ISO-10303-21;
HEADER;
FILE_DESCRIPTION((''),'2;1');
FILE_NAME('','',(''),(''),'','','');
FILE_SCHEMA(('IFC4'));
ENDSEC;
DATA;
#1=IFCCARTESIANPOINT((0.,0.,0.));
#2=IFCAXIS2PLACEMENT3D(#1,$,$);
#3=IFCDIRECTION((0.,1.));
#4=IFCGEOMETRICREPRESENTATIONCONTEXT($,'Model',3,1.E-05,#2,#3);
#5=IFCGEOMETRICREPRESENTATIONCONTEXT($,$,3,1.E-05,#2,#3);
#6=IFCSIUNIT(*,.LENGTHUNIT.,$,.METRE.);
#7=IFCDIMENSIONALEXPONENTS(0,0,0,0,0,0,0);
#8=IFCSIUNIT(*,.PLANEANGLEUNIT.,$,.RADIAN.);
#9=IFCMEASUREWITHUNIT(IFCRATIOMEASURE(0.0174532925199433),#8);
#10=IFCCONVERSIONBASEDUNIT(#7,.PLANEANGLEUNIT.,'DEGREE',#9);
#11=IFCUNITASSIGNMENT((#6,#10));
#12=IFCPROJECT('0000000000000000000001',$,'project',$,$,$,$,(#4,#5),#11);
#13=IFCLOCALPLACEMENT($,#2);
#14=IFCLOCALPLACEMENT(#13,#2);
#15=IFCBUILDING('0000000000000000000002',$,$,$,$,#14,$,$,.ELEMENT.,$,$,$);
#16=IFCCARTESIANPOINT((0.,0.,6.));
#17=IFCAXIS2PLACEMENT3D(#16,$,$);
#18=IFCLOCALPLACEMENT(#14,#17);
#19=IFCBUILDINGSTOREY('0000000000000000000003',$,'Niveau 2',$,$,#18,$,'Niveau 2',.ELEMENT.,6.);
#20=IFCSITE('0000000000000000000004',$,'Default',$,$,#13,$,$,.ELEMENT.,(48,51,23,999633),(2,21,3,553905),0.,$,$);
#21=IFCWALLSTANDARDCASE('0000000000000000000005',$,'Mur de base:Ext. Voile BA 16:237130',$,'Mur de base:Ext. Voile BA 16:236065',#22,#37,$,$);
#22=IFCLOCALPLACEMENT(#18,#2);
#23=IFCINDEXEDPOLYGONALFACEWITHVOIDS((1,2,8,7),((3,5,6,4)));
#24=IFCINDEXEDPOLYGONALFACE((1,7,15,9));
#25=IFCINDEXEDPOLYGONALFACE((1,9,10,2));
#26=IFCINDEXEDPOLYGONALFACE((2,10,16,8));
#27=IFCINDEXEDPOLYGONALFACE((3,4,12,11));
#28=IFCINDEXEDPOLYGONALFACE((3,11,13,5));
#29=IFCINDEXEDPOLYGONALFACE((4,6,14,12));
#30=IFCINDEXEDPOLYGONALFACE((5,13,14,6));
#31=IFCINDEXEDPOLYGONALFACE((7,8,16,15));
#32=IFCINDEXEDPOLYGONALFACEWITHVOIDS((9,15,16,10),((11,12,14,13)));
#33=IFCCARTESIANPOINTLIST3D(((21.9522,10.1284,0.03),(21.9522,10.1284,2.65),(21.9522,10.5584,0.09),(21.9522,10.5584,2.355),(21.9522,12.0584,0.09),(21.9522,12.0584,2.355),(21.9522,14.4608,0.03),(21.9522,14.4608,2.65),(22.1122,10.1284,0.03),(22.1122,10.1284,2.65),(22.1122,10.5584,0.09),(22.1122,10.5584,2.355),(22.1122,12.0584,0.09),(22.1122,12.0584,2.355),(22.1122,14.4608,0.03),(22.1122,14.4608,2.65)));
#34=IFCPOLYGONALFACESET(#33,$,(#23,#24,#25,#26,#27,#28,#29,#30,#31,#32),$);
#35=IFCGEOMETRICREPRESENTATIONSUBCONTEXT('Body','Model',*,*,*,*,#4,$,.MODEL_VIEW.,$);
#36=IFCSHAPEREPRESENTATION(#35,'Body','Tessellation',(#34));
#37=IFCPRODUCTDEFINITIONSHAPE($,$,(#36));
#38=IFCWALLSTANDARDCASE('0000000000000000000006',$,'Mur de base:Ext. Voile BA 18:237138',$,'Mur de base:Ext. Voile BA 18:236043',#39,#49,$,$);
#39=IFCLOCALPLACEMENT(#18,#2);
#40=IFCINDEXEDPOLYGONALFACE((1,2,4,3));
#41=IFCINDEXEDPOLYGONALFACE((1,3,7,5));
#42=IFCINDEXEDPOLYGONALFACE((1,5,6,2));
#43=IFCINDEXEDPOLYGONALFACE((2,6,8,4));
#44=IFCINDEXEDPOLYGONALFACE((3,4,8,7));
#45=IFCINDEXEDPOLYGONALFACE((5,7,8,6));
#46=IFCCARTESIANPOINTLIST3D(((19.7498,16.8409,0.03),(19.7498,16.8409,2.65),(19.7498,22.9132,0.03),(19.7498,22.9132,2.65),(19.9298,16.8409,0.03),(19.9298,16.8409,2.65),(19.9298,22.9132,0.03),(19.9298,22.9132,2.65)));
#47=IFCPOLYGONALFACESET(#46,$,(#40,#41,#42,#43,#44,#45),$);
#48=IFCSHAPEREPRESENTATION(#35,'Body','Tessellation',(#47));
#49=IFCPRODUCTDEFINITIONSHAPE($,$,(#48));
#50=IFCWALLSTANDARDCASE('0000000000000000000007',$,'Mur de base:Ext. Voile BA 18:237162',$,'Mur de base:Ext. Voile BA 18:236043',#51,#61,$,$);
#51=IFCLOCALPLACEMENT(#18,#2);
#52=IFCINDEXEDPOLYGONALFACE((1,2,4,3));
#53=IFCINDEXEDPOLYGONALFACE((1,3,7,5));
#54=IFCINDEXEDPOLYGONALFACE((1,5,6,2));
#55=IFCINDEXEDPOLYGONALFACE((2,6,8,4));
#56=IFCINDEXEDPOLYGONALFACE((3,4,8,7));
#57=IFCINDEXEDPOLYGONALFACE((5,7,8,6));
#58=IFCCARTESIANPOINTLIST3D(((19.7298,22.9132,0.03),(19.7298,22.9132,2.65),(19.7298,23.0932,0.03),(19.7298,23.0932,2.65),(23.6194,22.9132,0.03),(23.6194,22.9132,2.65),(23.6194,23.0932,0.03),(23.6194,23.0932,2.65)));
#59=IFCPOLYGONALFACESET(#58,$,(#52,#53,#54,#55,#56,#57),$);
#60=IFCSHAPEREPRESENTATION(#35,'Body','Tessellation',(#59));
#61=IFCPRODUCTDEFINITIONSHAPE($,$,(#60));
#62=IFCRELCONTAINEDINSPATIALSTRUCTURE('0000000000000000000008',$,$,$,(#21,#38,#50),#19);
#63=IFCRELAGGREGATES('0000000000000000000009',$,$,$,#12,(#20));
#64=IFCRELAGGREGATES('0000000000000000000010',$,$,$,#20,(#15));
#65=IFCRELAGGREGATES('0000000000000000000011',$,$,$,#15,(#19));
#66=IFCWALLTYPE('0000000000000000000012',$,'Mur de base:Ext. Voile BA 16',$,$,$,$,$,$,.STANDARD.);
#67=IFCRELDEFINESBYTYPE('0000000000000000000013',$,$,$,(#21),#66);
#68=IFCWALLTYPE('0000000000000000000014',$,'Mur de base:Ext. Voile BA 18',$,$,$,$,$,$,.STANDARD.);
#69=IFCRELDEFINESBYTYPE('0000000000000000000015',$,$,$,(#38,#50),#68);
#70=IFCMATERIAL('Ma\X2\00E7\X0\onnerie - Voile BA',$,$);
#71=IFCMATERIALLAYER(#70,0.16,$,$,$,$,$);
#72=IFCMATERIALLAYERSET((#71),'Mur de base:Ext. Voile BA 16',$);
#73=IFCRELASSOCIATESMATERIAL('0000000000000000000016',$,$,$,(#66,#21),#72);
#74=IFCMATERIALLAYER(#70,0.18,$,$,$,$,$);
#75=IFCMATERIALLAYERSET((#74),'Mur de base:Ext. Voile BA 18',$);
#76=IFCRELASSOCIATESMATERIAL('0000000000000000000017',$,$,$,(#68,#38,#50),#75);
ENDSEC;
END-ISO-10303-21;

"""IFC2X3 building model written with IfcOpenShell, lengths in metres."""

from ifc_helpers import new_model, entity, si_unit, converted_unit, direction, frame, frame_2d, origin, origin_2d_with_axis, place, context, subcontext, project, spatial, rectangle, extrude, material, layer, layer_set, layer_usage, type_object, element, save


model = new_model("IFC2X3")

# Units and contexts
model_context = context("Model", 3, precision=1e-05, world=origin(), true_north=direction((0.0, 1.0)))
context_of_model = context(None, 3, precision=1e-05, world=origin(), true_north=direction((0.0, 1.0)))
body_context = subcontext(model_context, "Body", "Model", "MODEL_VIEW")
ifc_project = project(units=[si_unit("LENGTHUNIT", "METRE"), converted_unit("PLANEANGLEUNIT", "DEGREE", entity("IfcRatioMeasure", 0.0174532925199433), si_unit("PLANEANGLEUNIT", "RADIAN"), dimensions=[0, 0, 0, 0, 0, 0, 0])], contexts=[model_context, context_of_model])

# Site, building, storey
site_placement = place(None, origin())
site = spatial("IfcSite", under=ifc_project, at=site_placement, Name="Default", CompositionType="ELEMENT", RefLatitude=(48, 51, 23, 999633), RefLongitude=(2, 21, 3, 553905), RefElevation=0.0)
building_placement = place(site_placement, origin())
building = spatial("IfcBuilding", under=site, at=building_placement, CompositionType="ELEMENT")
storey_placement = place(building_placement, frame((0.0, 0.0, 6.0)))
storey = spatial("IfcBuildingStorey", under=building, at=storey_placement, Name="Niveau 2", LongName="Niveau 2", CompositionType="ELEMENT", Elevation=6.0)

# Shared definitions
ifc_material = material(Name="Maçonnerie - Voile BA")

# Shared definitions
ifc_layer_1 = layer(ifc_material, 0.16)
ifc_layer_set_1 = layer_set([ifc_layer_1], Name="Mur de base:Ext. Voile BA 16")
wall_type_1 = type_object("IfcWallType", Name="Mur de base:Ext. Voile BA 16", PredefinedType="STANDARD", material=ifc_layer_set_1)

# Wall, opening
ifc_layer_usage_1 = layer_usage(ifc_layer_set_1, "AXIS2", "NEGATIVE", 0.08)
wall_1_placement = place(storey_placement, frame((22.0322, 14.4608, 0.03), z_axis=(0.0, 0.0, 1.0), x_axis=(0.0, -1.0, 0.0)))
wall_1 = element("IfcWallStandardCase", 1, at=wall_1_placement, inside=storey, type_object=wall_type_1, material=ifc_layer_usage_1, Name="Mur de base:Ext. Voile BA 16:237130", ObjectType="Mur de base:Ext. Voile BA 16:236065", context=body_context, shape_type="SweptSolid", body=[
    extrude(rectangle(XDim=4.3324, YDim=0.16, at=frame_2d((2.1662, 0.0), x_axis=(-1.0, 0.0))), origin(), (0.0, 0.0, 1.0), 2.62),
])
opening_1_placement = place(wall_1_placement, origin())
element("IfcOpeningElement", 2, at=opening_1_placement, cuts=wall_1, ObjectType="Opening", context=body_context, shape_type="SweptSolid", body=[
    extrude(rectangle(XDim=2.265, YDim=1.5, at=origin_2d_with_axis()), frame((3.1524, -0.08, 1.1925), z_axis=(0.0, 1.0, 0.0), x_axis=(0.0, 0.0, -1.0)), (0.0, 0.0, 1.0), 0.16),
])

# Walls
ifc_layer_2 = layer(ifc_material, 0.18)
ifc_layer_set_2 = layer_set([ifc_layer_2], Name="Mur de base:Ext. Voile BA 18")
ifc_layer_usage_2 = layer_usage(ifc_layer_set_2, "AXIS2", "NEGATIVE", 0.09)
wall_type_2 = type_object("IfcWallType", Name="Mur de base:Ext. Voile BA 18", PredefinedType="STANDARD", material=ifc_layer_set_2)
wall_2_placement = place(storey_placement, frame((19.8398, 16.8409, 0.03), z_axis=(0.0, 0.0, 1.0), x_axis=(0.0, 1.0, 0.0)))
element("IfcWallStandardCase", 3, at=wall_2_placement, inside=storey, type_object=wall_type_2, material=ifc_layer_usage_2, Name="Mur de base:Ext. Voile BA 18:237138", ObjectType="Mur de base:Ext. Voile BA 18:236043", context=body_context, shape_type="SweptSolid", body=[
    extrude(rectangle(XDim=6.0722, YDim=0.18, at=frame_2d((3.0361, 0.0), x_axis=(-1.0, 0.0))), origin(), (0.0, 0.0, 1.0), 2.62),
])
ifc_layer_usage_3 = layer_usage(ifc_layer_set_2, "AXIS2", "NEGATIVE", 0.09)
wall_3_placement = place(storey_placement, frame((23.6194, 23.0032, 0.03), z_axis=(0.0, 0.0, 1.0), x_axis=(-1.0, 0.0, 0.0)))
element("IfcWallStandardCase", 4, at=wall_3_placement, inside=storey, type_object=wall_type_2, material=ifc_layer_usage_3, Name="Mur de base:Ext. Voile BA 18:237162", ObjectType="Mur de base:Ext. Voile BA 18:236043", context=body_context, shape_type="SweptSolid", body=[
    extrude(rectangle(XDim=3.8895, YDim=0.18, at=frame_2d((1.9448, 0.0), x_axis=(-1.0, 0.0))), origin(), (0.0, 0.0, 1.0), 2.62),
])

save(model, "model.ifc")
